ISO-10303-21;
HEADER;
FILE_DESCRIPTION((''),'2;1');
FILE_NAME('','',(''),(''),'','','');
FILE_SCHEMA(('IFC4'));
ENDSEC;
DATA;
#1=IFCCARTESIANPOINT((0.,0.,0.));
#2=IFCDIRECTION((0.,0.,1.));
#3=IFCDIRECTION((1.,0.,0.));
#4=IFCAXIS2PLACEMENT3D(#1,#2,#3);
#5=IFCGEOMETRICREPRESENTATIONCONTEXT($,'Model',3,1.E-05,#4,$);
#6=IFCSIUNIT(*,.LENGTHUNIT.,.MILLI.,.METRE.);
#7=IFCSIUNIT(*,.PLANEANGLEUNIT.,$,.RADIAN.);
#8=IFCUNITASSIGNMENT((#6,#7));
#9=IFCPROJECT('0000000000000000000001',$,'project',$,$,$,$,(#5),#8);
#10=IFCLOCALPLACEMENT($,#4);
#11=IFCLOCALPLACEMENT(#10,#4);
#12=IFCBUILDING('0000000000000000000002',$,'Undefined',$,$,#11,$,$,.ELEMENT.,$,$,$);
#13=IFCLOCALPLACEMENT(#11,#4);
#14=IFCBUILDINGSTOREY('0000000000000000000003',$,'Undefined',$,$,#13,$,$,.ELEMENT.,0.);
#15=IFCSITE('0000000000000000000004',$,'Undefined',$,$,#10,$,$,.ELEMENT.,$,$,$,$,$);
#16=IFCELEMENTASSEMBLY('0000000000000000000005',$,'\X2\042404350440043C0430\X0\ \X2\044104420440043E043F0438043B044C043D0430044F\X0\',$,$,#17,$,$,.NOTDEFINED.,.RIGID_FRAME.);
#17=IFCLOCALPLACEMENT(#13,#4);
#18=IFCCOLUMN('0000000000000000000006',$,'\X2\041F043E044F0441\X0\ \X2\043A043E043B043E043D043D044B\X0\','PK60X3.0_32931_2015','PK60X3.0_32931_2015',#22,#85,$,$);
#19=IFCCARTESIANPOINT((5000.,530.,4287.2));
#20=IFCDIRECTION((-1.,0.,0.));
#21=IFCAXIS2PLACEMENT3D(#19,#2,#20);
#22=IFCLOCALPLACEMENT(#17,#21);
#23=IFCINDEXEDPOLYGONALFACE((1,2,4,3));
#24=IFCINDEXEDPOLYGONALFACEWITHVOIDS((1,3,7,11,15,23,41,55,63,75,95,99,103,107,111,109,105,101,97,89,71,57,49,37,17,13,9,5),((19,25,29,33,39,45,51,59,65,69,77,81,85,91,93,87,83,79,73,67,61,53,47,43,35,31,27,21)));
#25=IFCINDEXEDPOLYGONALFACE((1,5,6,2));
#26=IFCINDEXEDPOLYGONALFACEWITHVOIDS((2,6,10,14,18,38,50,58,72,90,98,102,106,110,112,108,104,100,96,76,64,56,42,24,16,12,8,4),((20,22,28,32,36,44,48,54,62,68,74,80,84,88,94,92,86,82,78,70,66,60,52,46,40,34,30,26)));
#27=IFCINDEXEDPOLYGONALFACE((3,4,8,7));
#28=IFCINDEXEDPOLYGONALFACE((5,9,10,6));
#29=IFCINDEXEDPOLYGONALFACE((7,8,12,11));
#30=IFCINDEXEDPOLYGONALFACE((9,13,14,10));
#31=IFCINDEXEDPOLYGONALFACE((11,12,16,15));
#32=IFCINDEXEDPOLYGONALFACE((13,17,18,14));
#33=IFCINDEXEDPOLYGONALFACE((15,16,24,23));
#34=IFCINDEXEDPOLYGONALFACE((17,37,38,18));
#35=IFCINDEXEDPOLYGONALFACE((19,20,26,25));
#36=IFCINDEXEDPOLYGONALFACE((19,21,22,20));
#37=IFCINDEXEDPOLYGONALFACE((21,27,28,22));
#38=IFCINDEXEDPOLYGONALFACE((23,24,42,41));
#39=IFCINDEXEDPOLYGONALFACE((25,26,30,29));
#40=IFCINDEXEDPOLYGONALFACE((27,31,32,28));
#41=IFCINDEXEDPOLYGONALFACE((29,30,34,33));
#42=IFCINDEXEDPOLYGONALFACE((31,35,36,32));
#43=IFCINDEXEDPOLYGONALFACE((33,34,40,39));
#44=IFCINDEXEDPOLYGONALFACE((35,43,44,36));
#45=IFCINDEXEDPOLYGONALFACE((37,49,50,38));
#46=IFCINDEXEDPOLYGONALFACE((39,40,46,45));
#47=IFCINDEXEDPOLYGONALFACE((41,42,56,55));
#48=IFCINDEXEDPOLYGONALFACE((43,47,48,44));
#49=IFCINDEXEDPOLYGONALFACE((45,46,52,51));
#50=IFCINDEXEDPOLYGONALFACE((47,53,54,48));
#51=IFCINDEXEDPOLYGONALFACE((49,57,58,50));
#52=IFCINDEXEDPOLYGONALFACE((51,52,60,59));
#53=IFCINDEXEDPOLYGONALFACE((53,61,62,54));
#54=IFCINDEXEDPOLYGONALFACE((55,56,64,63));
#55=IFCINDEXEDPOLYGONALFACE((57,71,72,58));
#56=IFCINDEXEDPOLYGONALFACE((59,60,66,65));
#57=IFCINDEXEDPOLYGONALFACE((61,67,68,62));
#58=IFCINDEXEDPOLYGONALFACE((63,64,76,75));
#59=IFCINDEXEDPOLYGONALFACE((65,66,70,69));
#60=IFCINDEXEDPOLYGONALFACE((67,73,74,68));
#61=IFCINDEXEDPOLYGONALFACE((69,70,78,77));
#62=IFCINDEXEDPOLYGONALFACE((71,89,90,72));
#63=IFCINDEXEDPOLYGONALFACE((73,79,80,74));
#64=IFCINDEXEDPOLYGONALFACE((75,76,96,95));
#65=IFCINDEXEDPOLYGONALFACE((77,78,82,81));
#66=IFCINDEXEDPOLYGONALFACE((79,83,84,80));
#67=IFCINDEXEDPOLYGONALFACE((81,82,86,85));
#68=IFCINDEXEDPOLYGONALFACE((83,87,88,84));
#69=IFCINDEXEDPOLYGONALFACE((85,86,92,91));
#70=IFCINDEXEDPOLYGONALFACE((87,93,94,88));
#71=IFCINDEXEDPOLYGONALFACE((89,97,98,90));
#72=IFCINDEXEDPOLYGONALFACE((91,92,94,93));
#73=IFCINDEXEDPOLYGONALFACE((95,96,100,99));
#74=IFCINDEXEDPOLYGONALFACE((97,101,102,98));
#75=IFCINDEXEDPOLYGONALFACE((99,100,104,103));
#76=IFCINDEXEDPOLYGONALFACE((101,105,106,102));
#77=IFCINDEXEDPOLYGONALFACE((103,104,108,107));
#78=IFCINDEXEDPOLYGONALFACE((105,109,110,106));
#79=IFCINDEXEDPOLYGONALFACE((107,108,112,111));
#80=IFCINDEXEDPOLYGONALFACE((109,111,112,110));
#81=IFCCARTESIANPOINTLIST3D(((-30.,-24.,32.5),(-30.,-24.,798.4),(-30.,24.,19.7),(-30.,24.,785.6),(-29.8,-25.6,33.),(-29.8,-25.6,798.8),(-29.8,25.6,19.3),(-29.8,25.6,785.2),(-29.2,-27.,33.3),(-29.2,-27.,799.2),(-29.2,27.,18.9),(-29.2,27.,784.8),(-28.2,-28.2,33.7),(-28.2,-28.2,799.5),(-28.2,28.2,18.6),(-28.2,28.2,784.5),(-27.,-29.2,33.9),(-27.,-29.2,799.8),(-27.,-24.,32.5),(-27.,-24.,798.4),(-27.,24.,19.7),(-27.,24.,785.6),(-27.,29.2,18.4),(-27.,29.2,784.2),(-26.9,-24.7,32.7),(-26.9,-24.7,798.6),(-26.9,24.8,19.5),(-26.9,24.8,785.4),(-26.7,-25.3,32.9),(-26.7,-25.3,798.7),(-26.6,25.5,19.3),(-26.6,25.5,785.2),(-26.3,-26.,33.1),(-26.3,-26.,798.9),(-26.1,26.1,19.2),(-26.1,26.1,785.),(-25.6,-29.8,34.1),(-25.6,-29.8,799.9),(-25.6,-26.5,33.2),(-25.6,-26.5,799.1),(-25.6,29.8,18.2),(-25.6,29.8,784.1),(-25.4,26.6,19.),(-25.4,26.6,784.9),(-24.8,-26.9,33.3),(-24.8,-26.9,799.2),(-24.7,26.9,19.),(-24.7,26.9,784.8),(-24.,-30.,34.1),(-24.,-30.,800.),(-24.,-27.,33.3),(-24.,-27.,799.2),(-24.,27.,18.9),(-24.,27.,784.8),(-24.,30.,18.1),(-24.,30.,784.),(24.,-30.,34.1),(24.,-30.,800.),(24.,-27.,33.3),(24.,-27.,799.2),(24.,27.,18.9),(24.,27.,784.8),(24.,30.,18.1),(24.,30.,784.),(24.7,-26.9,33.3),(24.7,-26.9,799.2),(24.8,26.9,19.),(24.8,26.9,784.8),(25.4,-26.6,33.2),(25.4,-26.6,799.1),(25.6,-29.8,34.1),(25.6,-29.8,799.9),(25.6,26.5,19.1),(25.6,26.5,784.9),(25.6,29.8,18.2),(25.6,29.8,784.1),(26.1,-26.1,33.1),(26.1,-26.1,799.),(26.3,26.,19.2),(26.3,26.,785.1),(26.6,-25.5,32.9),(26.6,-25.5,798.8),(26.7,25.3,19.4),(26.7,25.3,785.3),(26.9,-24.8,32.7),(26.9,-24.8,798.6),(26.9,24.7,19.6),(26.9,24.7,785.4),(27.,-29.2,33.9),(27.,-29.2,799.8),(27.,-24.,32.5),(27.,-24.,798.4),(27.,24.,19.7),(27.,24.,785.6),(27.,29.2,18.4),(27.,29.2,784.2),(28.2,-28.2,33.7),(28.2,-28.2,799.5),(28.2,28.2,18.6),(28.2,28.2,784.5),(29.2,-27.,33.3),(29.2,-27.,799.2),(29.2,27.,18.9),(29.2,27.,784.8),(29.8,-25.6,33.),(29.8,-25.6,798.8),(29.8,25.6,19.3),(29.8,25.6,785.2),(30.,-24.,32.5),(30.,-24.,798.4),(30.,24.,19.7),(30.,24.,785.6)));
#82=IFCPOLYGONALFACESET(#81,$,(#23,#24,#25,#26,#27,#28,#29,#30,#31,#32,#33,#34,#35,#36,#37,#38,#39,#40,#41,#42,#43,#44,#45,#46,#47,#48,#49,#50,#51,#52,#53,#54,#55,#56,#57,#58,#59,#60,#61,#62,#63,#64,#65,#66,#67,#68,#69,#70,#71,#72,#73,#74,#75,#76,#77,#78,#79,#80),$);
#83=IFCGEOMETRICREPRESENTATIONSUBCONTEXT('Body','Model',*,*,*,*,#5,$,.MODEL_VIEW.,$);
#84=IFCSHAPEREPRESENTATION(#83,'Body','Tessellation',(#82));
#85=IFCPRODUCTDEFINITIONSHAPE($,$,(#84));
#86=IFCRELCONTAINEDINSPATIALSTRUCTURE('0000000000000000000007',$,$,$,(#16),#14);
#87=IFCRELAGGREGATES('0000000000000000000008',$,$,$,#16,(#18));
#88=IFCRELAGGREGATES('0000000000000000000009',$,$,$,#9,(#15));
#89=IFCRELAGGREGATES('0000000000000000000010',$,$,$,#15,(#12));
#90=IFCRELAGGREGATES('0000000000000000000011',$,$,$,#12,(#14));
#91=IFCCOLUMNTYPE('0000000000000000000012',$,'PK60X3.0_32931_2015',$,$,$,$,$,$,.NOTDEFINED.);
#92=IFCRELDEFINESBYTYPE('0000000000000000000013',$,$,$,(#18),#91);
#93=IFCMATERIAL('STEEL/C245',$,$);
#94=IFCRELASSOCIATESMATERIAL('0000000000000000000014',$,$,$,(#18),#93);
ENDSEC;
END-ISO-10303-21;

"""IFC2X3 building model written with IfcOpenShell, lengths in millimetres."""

from ifc_helpers import new_model, si_unit, frame, origin_with_axes, origin_2d_with_axis, place, context, subcontext, project, spatial, hollow_rectangle, extrude, clip, halfspace, material, type_object, element, aggregate, save


model = new_model("IFC2X3")

# Units and contexts
model_context = context("Model", 3, precision=1e-05, world=origin_with_axes())
body_context = subcontext(model_context, "Body", "Model", "MODEL_VIEW")
ifc_project = project(units=[si_unit("LENGTHUNIT", "METRE", prefix="MILLI"), si_unit("PLANEANGLEUNIT", "RADIAN")], contexts=[model_context])

# Site, building, storey
site_placement = place(None, origin_with_axes())
site = spatial("IfcSite", under=ifc_project, at=site_placement, Name="Undefined", CompositionType="ELEMENT")
building_placement = place(site_placement, origin_with_axes())
building = spatial("IfcBuilding", under=site, at=building_placement, Name="Undefined", CompositionType="ELEMENT")
storey_placement = place(building_placement, origin_with_axes())
storey = spatial("IfcBuildingStorey", under=building, at=storey_placement, Name="Undefined", CompositionType="ELEMENT", Elevation=0.0)

# Shared definitions
ifc_material_1 = material(Name="STEEL/C245")
column_type = type_object("IfcColumnType", Name="PK60X3.0_32931_2015", PredefinedType="NOTDEFINED")

# Element assembly, column
assembly_1_placement = place(storey_placement, origin_with_axes())
assembly_1 = element("IfcElementAssembly", 1, at=assembly_1_placement, inside=storey, Name="Ферма стропильная", AssemblyPlace="NOTDEFINED", PredefinedType="RIGID_FRAME")
column_1_placement = place(assembly_1_placement, frame((5000.0, 530.0, 4287.2), z_axis=(0.0, 0.0, 1.0), x_axis=(-1.0, 0.0, 0.0)))
column_1 = element("IfcColumn", 2, at=column_1_placement, type_object=column_type, material=ifc_material_1, Name="Пояс колонны", Description="PK60X3.0_32931_2015", ObjectType="PK60X3.0_32931_2015", context=body_context, shape_type="Clipping", body=[
    clip(clip(extrude(hollow_rectangle(XDim=60.0, YDim=60.0, WallThickness=3.0, InnerFilletRadius=3.0, OuterFilletRadius=6.0, at=origin_2d_with_axis()), frame((0.0, 0.0, 808.2), z_axis=(0.0, 0.0, -1.0), x_axis=(0.0, 1.0, 0.0)), (0.0, 0.0, 1.0), 798.2), halfspace(frame((0.0, 84.9, 769.4), z_axis=(0.0, -0.257663, -0.966235), x_axis=(-1.0, 0.0, 0.0)), True)), halfspace(frame((0.0, 49.4, 13.0), z_axis=(0.0, -0.257663, -0.966235), x_axis=(-1.0, 0.0, 0.0)), False)),
])

aggregate(assembly_1, [column_1])

save(model, "model.ifc")
